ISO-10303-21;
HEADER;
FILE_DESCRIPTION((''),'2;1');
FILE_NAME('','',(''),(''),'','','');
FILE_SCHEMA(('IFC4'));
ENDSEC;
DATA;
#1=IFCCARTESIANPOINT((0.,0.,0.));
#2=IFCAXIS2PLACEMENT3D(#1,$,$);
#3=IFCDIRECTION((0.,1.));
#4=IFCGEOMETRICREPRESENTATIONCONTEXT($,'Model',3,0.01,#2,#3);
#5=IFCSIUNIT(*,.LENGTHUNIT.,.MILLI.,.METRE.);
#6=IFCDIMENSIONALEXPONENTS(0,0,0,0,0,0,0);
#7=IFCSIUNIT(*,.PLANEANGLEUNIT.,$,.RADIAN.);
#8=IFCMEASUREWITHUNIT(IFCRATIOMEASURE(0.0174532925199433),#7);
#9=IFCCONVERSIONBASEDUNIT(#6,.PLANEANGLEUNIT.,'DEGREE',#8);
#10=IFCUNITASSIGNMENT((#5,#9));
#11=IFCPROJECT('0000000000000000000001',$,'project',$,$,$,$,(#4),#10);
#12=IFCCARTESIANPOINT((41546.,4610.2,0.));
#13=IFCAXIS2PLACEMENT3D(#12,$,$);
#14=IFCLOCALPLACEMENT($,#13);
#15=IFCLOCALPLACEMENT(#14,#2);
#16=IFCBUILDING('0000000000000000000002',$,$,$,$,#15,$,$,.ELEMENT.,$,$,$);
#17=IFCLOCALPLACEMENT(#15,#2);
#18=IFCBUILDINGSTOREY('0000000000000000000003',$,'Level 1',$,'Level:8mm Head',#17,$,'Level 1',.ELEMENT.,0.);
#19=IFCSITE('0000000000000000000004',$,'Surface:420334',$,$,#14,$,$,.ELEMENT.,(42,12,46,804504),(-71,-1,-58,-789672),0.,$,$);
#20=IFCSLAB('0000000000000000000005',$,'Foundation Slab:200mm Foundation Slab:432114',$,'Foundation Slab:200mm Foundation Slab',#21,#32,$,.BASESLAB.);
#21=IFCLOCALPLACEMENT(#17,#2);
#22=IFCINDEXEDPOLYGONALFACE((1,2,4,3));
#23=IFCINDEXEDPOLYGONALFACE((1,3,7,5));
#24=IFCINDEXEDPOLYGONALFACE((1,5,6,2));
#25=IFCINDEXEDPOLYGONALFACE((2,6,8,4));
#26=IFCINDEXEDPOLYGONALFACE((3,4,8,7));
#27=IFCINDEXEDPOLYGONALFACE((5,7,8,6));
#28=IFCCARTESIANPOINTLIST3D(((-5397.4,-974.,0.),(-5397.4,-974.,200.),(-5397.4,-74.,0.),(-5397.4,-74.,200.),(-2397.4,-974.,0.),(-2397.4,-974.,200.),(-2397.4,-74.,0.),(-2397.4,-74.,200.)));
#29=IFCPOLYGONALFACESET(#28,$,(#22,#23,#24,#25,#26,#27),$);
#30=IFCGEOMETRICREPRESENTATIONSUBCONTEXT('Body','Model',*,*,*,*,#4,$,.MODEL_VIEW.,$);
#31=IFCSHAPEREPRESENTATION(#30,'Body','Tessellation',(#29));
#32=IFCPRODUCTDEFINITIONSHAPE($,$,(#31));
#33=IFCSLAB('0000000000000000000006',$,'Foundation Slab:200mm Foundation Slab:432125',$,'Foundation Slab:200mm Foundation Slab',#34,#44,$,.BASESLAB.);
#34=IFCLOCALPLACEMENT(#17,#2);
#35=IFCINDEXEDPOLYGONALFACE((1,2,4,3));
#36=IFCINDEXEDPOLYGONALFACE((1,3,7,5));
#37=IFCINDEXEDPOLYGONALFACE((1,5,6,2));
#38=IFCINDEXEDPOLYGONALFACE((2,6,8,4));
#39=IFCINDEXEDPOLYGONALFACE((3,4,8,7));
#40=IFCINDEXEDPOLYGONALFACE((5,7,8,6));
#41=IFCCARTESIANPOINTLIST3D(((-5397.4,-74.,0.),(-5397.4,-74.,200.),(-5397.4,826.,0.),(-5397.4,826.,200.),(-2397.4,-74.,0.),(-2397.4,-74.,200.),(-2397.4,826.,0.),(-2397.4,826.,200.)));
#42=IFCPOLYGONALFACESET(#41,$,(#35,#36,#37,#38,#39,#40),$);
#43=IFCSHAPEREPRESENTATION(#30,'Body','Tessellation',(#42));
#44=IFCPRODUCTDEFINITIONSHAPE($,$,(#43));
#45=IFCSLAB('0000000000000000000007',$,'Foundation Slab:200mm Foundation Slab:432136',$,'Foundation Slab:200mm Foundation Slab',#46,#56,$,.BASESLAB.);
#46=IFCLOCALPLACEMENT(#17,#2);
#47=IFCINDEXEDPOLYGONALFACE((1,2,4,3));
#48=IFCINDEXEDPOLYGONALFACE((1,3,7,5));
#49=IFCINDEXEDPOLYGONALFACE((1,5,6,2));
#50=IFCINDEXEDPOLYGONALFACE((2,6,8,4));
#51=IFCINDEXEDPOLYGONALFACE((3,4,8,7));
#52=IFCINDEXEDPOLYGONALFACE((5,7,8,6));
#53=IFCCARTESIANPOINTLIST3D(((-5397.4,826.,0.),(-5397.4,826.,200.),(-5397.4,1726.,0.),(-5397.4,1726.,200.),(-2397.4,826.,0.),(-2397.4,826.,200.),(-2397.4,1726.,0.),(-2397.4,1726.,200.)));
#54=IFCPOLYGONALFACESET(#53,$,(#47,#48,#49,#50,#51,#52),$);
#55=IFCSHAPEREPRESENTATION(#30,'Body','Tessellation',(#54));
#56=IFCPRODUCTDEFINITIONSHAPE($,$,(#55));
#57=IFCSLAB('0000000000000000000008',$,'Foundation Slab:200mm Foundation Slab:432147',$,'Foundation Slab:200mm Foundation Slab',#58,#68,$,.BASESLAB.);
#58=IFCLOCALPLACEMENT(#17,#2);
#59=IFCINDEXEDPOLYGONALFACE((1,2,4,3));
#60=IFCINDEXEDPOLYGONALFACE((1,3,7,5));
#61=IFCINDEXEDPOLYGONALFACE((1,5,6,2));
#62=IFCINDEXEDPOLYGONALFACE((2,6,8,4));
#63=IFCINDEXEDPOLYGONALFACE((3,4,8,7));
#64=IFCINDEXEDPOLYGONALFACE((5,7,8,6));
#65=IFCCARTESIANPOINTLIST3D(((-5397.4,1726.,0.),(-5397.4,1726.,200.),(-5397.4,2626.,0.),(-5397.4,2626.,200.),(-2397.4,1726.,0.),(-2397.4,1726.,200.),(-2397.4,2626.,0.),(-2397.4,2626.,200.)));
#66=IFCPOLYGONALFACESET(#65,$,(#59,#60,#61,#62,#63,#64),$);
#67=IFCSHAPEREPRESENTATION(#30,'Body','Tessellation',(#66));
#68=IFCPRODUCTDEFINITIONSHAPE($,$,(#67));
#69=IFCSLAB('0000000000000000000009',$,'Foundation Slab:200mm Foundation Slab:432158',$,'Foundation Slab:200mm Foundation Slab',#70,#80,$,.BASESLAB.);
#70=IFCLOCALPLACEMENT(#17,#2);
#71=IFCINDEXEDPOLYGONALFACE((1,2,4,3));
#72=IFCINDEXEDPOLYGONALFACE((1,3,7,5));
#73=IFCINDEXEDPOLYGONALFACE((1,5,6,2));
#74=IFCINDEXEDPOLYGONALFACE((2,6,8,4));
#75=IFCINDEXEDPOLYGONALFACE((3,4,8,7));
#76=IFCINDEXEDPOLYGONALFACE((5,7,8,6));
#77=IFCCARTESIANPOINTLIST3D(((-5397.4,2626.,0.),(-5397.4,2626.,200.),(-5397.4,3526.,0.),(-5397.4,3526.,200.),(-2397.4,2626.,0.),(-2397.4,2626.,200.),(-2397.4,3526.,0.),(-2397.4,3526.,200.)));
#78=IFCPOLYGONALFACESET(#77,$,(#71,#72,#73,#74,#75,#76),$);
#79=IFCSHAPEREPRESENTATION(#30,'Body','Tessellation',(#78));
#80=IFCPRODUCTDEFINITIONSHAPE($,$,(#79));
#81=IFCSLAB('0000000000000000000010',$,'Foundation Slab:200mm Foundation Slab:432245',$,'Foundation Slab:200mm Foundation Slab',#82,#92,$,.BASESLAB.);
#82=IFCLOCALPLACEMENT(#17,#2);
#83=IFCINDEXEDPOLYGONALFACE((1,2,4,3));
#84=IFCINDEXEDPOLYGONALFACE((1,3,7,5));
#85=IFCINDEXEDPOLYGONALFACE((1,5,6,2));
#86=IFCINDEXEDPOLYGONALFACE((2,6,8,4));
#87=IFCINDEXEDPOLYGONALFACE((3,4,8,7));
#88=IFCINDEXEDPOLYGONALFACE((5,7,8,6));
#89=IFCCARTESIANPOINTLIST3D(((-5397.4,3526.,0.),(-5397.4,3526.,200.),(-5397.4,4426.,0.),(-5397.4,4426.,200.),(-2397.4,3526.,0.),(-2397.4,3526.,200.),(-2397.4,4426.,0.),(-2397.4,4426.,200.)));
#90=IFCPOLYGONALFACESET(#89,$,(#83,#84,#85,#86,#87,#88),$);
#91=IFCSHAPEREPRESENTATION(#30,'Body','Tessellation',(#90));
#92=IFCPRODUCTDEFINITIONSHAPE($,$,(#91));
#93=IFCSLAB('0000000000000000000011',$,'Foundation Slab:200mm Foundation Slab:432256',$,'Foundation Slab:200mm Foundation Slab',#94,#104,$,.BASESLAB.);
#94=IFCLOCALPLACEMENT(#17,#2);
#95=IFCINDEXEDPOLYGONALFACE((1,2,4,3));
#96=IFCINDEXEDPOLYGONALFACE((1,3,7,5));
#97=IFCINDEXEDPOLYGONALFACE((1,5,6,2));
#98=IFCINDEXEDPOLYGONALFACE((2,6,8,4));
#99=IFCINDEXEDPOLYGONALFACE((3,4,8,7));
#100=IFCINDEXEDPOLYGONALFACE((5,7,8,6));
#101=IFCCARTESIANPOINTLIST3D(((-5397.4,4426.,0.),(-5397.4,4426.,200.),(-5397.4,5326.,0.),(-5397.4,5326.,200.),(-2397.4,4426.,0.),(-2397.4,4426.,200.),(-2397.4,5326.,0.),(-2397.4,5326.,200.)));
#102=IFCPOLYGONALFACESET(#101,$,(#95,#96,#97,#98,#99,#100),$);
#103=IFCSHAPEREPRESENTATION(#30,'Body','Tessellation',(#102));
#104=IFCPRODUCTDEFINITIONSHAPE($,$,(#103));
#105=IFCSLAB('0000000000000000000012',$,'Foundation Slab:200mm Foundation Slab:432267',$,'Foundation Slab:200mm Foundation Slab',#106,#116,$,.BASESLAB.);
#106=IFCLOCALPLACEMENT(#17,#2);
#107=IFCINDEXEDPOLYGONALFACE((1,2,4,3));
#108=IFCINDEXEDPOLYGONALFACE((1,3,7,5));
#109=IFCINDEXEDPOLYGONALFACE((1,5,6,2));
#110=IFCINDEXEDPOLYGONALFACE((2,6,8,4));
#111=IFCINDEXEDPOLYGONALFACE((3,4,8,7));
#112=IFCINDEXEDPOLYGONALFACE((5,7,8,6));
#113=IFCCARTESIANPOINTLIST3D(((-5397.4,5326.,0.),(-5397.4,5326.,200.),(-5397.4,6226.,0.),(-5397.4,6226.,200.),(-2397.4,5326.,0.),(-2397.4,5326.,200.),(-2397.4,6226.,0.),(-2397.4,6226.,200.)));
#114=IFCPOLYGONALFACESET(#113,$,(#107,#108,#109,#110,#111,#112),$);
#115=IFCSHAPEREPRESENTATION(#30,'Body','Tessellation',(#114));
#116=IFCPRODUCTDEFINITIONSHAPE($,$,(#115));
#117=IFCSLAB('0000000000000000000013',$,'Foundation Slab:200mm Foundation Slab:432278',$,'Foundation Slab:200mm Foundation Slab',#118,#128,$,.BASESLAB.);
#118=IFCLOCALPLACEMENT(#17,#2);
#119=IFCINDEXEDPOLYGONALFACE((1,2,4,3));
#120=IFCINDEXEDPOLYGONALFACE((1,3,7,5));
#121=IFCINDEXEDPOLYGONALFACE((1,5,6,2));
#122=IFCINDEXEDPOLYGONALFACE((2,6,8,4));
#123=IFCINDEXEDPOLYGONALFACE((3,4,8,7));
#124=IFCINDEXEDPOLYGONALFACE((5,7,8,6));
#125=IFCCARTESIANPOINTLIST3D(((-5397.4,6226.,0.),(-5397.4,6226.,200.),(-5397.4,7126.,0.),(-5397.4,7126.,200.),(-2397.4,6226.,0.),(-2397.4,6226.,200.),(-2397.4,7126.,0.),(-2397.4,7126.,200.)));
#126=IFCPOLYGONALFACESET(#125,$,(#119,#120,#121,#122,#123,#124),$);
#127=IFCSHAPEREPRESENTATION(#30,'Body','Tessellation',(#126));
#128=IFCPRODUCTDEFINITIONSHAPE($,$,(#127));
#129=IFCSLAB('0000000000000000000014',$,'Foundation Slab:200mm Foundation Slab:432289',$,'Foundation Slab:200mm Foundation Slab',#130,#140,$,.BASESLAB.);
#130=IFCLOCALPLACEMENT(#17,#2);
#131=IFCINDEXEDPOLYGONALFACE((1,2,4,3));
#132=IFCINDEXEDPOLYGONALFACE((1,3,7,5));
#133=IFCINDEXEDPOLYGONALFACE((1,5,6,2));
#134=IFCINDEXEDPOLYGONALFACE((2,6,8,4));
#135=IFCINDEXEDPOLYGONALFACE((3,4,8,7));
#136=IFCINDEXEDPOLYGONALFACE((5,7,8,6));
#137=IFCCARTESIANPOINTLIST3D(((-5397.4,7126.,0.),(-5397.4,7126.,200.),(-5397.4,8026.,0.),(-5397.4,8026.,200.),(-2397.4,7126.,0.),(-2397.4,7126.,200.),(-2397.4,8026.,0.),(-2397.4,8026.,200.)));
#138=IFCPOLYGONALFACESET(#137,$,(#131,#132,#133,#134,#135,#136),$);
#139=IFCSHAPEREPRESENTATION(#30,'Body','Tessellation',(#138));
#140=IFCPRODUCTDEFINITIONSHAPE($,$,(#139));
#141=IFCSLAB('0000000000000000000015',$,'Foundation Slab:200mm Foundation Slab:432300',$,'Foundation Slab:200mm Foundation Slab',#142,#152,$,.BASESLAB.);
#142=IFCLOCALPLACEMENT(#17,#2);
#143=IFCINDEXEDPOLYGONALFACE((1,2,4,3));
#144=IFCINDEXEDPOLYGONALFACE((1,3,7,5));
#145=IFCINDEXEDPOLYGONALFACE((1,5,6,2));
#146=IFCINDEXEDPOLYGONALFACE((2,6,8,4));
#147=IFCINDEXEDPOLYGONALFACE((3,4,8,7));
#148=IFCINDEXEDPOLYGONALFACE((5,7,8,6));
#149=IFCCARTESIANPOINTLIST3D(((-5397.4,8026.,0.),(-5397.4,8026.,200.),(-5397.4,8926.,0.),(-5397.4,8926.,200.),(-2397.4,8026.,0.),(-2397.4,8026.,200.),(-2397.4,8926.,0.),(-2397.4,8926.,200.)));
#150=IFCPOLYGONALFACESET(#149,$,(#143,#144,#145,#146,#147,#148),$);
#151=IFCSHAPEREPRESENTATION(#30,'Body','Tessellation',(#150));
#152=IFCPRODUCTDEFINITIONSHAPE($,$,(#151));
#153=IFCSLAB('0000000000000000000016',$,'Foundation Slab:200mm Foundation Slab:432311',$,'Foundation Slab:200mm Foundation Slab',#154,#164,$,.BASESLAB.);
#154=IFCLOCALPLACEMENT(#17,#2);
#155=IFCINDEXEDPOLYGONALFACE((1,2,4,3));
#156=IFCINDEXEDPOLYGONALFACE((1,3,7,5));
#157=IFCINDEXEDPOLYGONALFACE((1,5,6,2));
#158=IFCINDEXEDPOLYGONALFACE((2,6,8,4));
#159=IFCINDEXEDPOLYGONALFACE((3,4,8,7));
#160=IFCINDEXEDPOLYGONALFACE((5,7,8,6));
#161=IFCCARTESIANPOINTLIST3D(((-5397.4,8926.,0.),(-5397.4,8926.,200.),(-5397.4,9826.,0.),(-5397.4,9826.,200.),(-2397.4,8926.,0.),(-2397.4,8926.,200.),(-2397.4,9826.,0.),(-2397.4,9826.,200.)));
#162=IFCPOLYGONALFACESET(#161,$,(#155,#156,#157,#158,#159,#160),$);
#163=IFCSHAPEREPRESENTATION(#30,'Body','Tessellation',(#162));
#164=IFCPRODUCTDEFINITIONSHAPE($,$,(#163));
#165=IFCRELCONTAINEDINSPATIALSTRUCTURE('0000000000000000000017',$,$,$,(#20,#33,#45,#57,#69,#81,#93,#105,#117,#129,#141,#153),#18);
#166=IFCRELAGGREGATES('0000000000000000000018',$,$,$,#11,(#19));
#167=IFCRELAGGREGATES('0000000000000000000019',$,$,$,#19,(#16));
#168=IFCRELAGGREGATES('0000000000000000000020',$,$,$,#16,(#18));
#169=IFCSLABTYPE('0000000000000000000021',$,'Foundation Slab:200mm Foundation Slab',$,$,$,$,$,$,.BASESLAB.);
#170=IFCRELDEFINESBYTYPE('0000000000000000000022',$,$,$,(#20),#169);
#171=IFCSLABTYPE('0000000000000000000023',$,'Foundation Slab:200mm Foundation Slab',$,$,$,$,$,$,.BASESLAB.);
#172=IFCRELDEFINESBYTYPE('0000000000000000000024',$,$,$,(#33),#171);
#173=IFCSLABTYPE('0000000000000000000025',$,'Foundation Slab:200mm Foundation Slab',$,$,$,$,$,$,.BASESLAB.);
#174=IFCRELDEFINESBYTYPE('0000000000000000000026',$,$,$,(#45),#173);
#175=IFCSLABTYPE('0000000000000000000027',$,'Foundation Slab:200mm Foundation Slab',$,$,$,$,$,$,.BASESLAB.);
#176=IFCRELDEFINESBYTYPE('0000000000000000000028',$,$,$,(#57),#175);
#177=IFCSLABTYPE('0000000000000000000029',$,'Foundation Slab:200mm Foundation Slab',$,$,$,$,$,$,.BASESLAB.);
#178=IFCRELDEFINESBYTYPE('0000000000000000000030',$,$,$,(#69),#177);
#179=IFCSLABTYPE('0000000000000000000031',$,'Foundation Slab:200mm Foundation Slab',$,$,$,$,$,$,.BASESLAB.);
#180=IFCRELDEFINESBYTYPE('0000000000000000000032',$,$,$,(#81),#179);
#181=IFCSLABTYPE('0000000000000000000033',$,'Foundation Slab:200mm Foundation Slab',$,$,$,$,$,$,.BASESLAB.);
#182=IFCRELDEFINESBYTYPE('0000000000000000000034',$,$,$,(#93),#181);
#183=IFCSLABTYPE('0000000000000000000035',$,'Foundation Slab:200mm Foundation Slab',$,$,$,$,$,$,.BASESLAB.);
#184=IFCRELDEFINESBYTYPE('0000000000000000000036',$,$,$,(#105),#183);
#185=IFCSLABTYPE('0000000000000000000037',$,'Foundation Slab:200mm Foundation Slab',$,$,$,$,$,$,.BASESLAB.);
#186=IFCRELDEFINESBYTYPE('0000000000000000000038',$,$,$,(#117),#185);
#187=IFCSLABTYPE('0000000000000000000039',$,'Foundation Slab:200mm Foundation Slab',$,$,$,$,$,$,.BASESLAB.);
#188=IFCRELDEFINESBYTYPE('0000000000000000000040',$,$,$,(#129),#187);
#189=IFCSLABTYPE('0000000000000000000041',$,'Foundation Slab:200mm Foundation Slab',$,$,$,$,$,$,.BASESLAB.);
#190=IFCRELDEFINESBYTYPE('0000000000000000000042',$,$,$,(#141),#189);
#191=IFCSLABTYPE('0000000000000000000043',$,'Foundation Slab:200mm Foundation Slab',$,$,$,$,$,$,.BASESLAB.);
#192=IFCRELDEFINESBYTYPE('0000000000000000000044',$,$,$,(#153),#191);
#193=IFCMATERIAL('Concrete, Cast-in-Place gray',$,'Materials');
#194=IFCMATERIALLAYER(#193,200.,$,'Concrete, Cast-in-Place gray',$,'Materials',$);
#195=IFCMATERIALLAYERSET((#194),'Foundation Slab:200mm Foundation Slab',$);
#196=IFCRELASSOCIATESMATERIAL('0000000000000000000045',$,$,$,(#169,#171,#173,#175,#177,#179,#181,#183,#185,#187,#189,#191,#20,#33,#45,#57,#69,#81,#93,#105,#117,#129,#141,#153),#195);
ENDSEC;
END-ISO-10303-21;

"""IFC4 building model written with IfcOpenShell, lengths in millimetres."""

from ifc_helpers import new_model, entity, si_unit, converted_unit, direction, frame, origin, origin_2d_with_axis, place, context, subcontext, project, spatial, rectangle, extrude, material, layer, layer_set, layer_usage, type_object, element, save


model = new_model("IFC4")

# Units and contexts
model_context = context("Model", 3, precision=0.01, world=origin(), true_north=direction((0.0, 1.0)))
body_context = subcontext(model_context, "Body", "Model", "MODEL_VIEW")
ifc_project = project(units=[si_unit("LENGTHUNIT", "METRE", prefix="MILLI"), converted_unit("PLANEANGLEUNIT", "DEGREE", entity("IfcRatioMeasure", 0.0174532925199433), si_unit("PLANEANGLEUNIT", "RADIAN"), dimensions=[0, 0, 0, 0, 0, 0, 0])], contexts=[model_context])

# Site, building, storey
site_placement = place(None, frame((41546.0, 4610.2, 0.0)))
site = spatial("IfcSite", under=ifc_project, at=site_placement, Name="Surface:420334", CompositionType="ELEMENT", RefLatitude=(42, 12, 46, 804504), RefLongitude=(-71, -1, -58, -789672), RefElevation=0.0)
building_placement = place(site_placement, origin())
building = spatial("IfcBuilding", under=site, at=building_placement, CompositionType="ELEMENT")
storey_placement = place(building_placement, origin())
storey = spatial("IfcBuildingStorey", under=building, at=storey_placement, Name="Level 1", ObjectType="Level:8mm Head", LongName="Level 1", CompositionType="ELEMENT", Elevation=0.0)

# Slabs
ifc_material = material(Name="Concrete, Cast-in-Place gray", Category="Materials")
ifc_layer = layer(ifc_material, 200.0, Name="Concrete, Cast-in-Place gray", Category="Materials")
ifc_layer_set = layer_set([ifc_layer], Name="Foundation Slab:200mm Foundation Slab")
ifc_layer_usage_1 = layer_usage(ifc_layer_set, "AXIS3", "POSITIVE", 0.0)
slab_type_1 = type_object("IfcSlabType", Name="Foundation Slab:200mm Foundation Slab", PredefinedType="BASESLAB", material=ifc_layer_set)
slab_1_placement = place(storey_placement, origin())
element("IfcSlab", 1, at=slab_1_placement, inside=storey, type_object=slab_type_1, material=ifc_layer_usage_1, Name="Foundation Slab:200mm Foundation Slab:432114", ObjectType="Foundation Slab:200mm Foundation Slab", PredefinedType="BASESLAB", context=body_context, shape_type="SweptSolid", body=[
    extrude(rectangle(XDim=900.0, YDim=3000.0, at=origin_2d_with_axis()), frame((-3897.4, -524.0, 200.0), z_axis=(0.0, 0.0, -1.0), x_axis=(0.0, 1.0, 0.0)), (0.0, 0.0, 1.0), 200.0),
])
ifc_layer_usage_2 = layer_usage(ifc_layer_set, "AXIS3", "POSITIVE", 0.0)
slab_type_2 = type_object("IfcSlabType", Name="Foundation Slab:200mm Foundation Slab", PredefinedType="BASESLAB", material=ifc_layer_set)
slab_2_placement = place(storey_placement, origin())
element("IfcSlab", 2, at=slab_2_placement, inside=storey, type_object=slab_type_2, material=ifc_layer_usage_2, Name="Foundation Slab:200mm Foundation Slab:432125", ObjectType="Foundation Slab:200mm Foundation Slab", PredefinedType="BASESLAB", context=body_context, shape_type="SweptSolid", body=[
    extrude(rectangle(XDim=900.0, YDim=3000.0, at=origin_2d_with_axis()), frame((-3897.4, 376.0, 200.0), z_axis=(0.0, 0.0, -1.0), x_axis=(0.0, 1.0, 0.0)), (0.0, 0.0, 1.0), 200.0),
])
ifc_layer_usage_3 = layer_usage(ifc_layer_set, "AXIS3", "POSITIVE", 0.0)
slab_type_3 = type_object("IfcSlabType", Name="Foundation Slab:200mm Foundation Slab", PredefinedType="BASESLAB", material=ifc_layer_set)
slab_3_placement = place(storey_placement, origin())
element("IfcSlab", 3, at=slab_3_placement, inside=storey, type_object=slab_type_3, material=ifc_layer_usage_3, Name="Foundation Slab:200mm Foundation Slab:432136", ObjectType="Foundation Slab:200mm Foundation Slab", PredefinedType="BASESLAB", context=body_context, shape_type="SweptSolid", body=[
    extrude(rectangle(XDim=900.0, YDim=3000.0, at=origin_2d_with_axis()), frame((-3897.4, 1276.0, 200.0), z_axis=(0.0, 0.0, -1.0), x_axis=(0.0, 1.0, 0.0)), (0.0, 0.0, 1.0), 200.0),
])
ifc_layer_usage_4 = layer_usage(ifc_layer_set, "AXIS3", "POSITIVE", 0.0)
slab_type_4 = type_object("IfcSlabType", Name="Foundation Slab:200mm Foundation Slab", PredefinedType="BASESLAB", material=ifc_layer_set)
slab_4_placement = place(storey_placement, origin())
element("IfcSlab", 4, at=slab_4_placement, inside=storey, type_object=slab_type_4, material=ifc_layer_usage_4, Name="Foundation Slab:200mm Foundation Slab:432147", ObjectType="Foundation Slab:200mm Foundation Slab", PredefinedType="BASESLAB", context=body_context, shape_type="SweptSolid", body=[
    extrude(rectangle(XDim=900.0, YDim=3000.0, at=origin_2d_with_axis()), frame((-3897.4, 2176.0, 200.0), z_axis=(0.0, 0.0, -1.0), x_axis=(0.0, 1.0, 0.0)), (0.0, 0.0, 1.0), 200.0),
])
ifc_layer_usage_5 = layer_usage(ifc_layer_set, "AXIS3", "POSITIVE", 0.0)
slab_type_5 = type_object("IfcSlabType", Name="Foundation Slab:200mm Foundation Slab", PredefinedType="BASESLAB", material=ifc_layer_set)
slab_5_placement = place(storey_placement, origin())
element("IfcSlab", 5, at=slab_5_placement, inside=storey, type_object=slab_type_5, material=ifc_layer_usage_5, Name="Foundation Slab:200mm Foundation Slab:432158", ObjectType="Foundation Slab:200mm Foundation Slab", PredefinedType="BASESLAB", context=body_context, shape_type="SweptSolid", body=[
    extrude(rectangle(XDim=900.0, YDim=3000.0, at=origin_2d_with_axis()), frame((-3897.4, 3076.0, 200.0), z_axis=(0.0, 0.0, -1.0), x_axis=(0.0, 1.0, 0.0)), (0.0, 0.0, 1.0), 200.0),
])
ifc_layer_usage_6 = layer_usage(ifc_layer_set, "AXIS3", "POSITIVE", 0.0)
slab_type_6 = type_object("IfcSlabType", Name="Foundation Slab:200mm Foundation Slab", PredefinedType="BASESLAB", material=ifc_layer_set)
slab_6_placement = place(storey_placement, origin())
element("IfcSlab", 6, at=slab_6_placement, inside=storey, type_object=slab_type_6, material=ifc_layer_usage_6, Name="Foundation Slab:200mm Foundation Slab:432245", ObjectType="Foundation Slab:200mm Foundation Slab", PredefinedType="BASESLAB", context=body_context, shape_type="SweptSolid", body=[
    extrude(rectangle(XDim=900.0, YDim=3000.0, at=origin_2d_with_axis()), frame((-3897.4, 3976.0, 200.0), z_axis=(0.0, 0.0, -1.0), x_axis=(0.0, 1.0, 0.0)), (0.0, 0.0, 1.0), 200.0),
])
ifc_layer_usage_7 = layer_usage(ifc_layer_set, "AXIS3", "POSITIVE", 0.0)
slab_type_7 = type_object("IfcSlabType", Name="Foundation Slab:200mm Foundation Slab", PredefinedType="BASESLAB", material=ifc_layer_set)
slab_7_placement = place(storey_placement, origin())
element("IfcSlab", 7, at=slab_7_placement, inside=storey, type_object=slab_type_7, material=ifc_layer_usage_7, Name="Foundation Slab:200mm Foundation Slab:432256", ObjectType="Foundation Slab:200mm Foundation Slab", PredefinedType="BASESLAB", context=body_context, shape_type="SweptSolid", body=[
    extrude(rectangle(XDim=900.0, YDim=3000.0, at=origin_2d_with_axis()), frame((-3897.4, 4876.0, 200.0), z_axis=(0.0, 0.0, -1.0), x_axis=(0.0, 1.0, 0.0)), (0.0, 0.0, 1.0), 200.0),
])
ifc_layer_usage_8 = layer_usage(ifc_layer_set, "AXIS3", "POSITIVE", 0.0)
slab_type_8 = type_object("IfcSlabType", Name="Foundation Slab:200mm Foundation Slab", PredefinedType="BASESLAB", material=ifc_layer_set)
slab_8_placement = place(storey_placement, origin())
element("IfcSlab", 8, at=slab_8_placement, inside=storey, type_object=slab_type_8, material=ifc_layer_usage_8, Name="Foundation Slab:200mm Foundation Slab:432267", ObjectType="Foundation Slab:200mm Foundation Slab", PredefinedType="BASESLAB", context=body_context, shape_type="SweptSolid", body=[
    extrude(rectangle(XDim=900.0, YDim=3000.0, at=origin_2d_with_axis()), frame((-3897.4, 5776.0, 200.0), z_axis=(0.0, 0.0, -1.0), x_axis=(0.0, 1.0, 0.0)), (0.0, 0.0, 1.0), 200.0),
])
ifc_layer_usage_9 = layer_usage(ifc_layer_set, "AXIS3", "POSITIVE", 0.0)
slab_type_9 = type_object("IfcSlabType", Name="Foundation Slab:200mm Foundation Slab", PredefinedType="BASESLAB", material=ifc_layer_set)
slab_9_placement = place(storey_placement, origin())
element("IfcSlab", 9, at=slab_9_placement, inside=storey, type_object=slab_type_9, material=ifc_layer_usage_9, Name="Foundation Slab:200mm Foundation Slab:432278", ObjectType="Foundation Slab:200mm Foundation Slab", PredefinedType="BASESLAB", context=body_context, shape_type="SweptSolid", body=[
    extrude(rectangle(XDim=900.0, YDim=3000.0, at=origin_2d_with_axis()), frame((-3897.4, 6676.0, 200.0), z_axis=(0.0, 0.0, -1.0), x_axis=(0.0, 1.0, 0.0)), (0.0, 0.0, 1.0), 200.0),
])
ifc_layer_usage_10 = layer_usage(ifc_layer_set, "AXIS3", "POSITIVE", 0.0)
slab_type_10 = type_object("IfcSlabType", Name="Foundation Slab:200mm Foundation Slab", PredefinedType="BASESLAB", material=ifc_layer_set)
slab_10_placement = place(storey_placement, origin())
element("IfcSlab", 10, at=slab_10_placement, inside=storey, type_object=slab_type_10, material=ifc_layer_usage_10, Name="Foundation Slab:200mm Foundation Slab:432289", ObjectType="Foundation Slab:200mm Foundation Slab", PredefinedType="BASESLAB", context=body_context, shape_type="SweptSolid", body=[
    extrude(rectangle(XDim=900.0, YDim=3000.0, at=origin_2d_with_axis()), frame((-3897.4, 7576.0, 200.0), z_axis=(0.0, 0.0, -1.0), x_axis=(0.0, 1.0, 0.0)), (0.0, 0.0, 1.0), 200.0),
])
ifc_layer_usage_11 = layer_usage(ifc_layer_set, "AXIS3", "POSITIVE", 0.0)
slab_type_11 = type_object("IfcSlabType", Name="Foundation Slab:200mm Foundation Slab", PredefinedType="BASESLAB", material=ifc_layer_set)
slab_11_placement = place(storey_placement, origin())
element("IfcSlab", 11, at=slab_11_placement, inside=storey, type_object=slab_type_11, material=ifc_layer_usage_11, Name="Foundation Slab:200mm Foundation Slab:432300", ObjectType="Foundation Slab:200mm Foundation Slab", PredefinedType="BASESLAB", context=body_context, shape_type="SweptSolid", body=[
    extrude(rectangle(XDim=900.0, YDim=3000.0, at=origin_2d_with_axis()), frame((-3897.4, 8476.0, 200.0), z_axis=(0.0, 0.0, -1.0), x_axis=(0.0, 1.0, 0.0)), (0.0, 0.0, 1.0), 200.0),
])
ifc_layer_usage_12 = layer_usage(ifc_layer_set, "AXIS3", "POSITIVE", 0.0)
slab_type_12 = type_object("IfcSlabType", Name="Foundation Slab:200mm Foundation Slab", PredefinedType="BASESLAB", material=ifc_layer_set)
slab_12_placement = place(storey_placement, origin())
element("IfcSlab", 12, at=slab_12_placement, inside=storey, type_object=slab_type_12, material=ifc_layer_usage_12, Name="Foundation Slab:200mm Foundation Slab:432311", ObjectType="Foundation Slab:200mm Foundation Slab", PredefinedType="BASESLAB", context=body_context, shape_type="SweptSolid", body=[
    extrude(rectangle(XDim=900.0, YDim=3000.0, at=origin_2d_with_axis()), frame((-3897.4, 9376.0, 200.0), z_axis=(0.0, 0.0, -1.0), x_axis=(0.0, 1.0, 0.0)), (0.0, 0.0, 1.0), 200.0),
])

save(model, "model.ifc")
